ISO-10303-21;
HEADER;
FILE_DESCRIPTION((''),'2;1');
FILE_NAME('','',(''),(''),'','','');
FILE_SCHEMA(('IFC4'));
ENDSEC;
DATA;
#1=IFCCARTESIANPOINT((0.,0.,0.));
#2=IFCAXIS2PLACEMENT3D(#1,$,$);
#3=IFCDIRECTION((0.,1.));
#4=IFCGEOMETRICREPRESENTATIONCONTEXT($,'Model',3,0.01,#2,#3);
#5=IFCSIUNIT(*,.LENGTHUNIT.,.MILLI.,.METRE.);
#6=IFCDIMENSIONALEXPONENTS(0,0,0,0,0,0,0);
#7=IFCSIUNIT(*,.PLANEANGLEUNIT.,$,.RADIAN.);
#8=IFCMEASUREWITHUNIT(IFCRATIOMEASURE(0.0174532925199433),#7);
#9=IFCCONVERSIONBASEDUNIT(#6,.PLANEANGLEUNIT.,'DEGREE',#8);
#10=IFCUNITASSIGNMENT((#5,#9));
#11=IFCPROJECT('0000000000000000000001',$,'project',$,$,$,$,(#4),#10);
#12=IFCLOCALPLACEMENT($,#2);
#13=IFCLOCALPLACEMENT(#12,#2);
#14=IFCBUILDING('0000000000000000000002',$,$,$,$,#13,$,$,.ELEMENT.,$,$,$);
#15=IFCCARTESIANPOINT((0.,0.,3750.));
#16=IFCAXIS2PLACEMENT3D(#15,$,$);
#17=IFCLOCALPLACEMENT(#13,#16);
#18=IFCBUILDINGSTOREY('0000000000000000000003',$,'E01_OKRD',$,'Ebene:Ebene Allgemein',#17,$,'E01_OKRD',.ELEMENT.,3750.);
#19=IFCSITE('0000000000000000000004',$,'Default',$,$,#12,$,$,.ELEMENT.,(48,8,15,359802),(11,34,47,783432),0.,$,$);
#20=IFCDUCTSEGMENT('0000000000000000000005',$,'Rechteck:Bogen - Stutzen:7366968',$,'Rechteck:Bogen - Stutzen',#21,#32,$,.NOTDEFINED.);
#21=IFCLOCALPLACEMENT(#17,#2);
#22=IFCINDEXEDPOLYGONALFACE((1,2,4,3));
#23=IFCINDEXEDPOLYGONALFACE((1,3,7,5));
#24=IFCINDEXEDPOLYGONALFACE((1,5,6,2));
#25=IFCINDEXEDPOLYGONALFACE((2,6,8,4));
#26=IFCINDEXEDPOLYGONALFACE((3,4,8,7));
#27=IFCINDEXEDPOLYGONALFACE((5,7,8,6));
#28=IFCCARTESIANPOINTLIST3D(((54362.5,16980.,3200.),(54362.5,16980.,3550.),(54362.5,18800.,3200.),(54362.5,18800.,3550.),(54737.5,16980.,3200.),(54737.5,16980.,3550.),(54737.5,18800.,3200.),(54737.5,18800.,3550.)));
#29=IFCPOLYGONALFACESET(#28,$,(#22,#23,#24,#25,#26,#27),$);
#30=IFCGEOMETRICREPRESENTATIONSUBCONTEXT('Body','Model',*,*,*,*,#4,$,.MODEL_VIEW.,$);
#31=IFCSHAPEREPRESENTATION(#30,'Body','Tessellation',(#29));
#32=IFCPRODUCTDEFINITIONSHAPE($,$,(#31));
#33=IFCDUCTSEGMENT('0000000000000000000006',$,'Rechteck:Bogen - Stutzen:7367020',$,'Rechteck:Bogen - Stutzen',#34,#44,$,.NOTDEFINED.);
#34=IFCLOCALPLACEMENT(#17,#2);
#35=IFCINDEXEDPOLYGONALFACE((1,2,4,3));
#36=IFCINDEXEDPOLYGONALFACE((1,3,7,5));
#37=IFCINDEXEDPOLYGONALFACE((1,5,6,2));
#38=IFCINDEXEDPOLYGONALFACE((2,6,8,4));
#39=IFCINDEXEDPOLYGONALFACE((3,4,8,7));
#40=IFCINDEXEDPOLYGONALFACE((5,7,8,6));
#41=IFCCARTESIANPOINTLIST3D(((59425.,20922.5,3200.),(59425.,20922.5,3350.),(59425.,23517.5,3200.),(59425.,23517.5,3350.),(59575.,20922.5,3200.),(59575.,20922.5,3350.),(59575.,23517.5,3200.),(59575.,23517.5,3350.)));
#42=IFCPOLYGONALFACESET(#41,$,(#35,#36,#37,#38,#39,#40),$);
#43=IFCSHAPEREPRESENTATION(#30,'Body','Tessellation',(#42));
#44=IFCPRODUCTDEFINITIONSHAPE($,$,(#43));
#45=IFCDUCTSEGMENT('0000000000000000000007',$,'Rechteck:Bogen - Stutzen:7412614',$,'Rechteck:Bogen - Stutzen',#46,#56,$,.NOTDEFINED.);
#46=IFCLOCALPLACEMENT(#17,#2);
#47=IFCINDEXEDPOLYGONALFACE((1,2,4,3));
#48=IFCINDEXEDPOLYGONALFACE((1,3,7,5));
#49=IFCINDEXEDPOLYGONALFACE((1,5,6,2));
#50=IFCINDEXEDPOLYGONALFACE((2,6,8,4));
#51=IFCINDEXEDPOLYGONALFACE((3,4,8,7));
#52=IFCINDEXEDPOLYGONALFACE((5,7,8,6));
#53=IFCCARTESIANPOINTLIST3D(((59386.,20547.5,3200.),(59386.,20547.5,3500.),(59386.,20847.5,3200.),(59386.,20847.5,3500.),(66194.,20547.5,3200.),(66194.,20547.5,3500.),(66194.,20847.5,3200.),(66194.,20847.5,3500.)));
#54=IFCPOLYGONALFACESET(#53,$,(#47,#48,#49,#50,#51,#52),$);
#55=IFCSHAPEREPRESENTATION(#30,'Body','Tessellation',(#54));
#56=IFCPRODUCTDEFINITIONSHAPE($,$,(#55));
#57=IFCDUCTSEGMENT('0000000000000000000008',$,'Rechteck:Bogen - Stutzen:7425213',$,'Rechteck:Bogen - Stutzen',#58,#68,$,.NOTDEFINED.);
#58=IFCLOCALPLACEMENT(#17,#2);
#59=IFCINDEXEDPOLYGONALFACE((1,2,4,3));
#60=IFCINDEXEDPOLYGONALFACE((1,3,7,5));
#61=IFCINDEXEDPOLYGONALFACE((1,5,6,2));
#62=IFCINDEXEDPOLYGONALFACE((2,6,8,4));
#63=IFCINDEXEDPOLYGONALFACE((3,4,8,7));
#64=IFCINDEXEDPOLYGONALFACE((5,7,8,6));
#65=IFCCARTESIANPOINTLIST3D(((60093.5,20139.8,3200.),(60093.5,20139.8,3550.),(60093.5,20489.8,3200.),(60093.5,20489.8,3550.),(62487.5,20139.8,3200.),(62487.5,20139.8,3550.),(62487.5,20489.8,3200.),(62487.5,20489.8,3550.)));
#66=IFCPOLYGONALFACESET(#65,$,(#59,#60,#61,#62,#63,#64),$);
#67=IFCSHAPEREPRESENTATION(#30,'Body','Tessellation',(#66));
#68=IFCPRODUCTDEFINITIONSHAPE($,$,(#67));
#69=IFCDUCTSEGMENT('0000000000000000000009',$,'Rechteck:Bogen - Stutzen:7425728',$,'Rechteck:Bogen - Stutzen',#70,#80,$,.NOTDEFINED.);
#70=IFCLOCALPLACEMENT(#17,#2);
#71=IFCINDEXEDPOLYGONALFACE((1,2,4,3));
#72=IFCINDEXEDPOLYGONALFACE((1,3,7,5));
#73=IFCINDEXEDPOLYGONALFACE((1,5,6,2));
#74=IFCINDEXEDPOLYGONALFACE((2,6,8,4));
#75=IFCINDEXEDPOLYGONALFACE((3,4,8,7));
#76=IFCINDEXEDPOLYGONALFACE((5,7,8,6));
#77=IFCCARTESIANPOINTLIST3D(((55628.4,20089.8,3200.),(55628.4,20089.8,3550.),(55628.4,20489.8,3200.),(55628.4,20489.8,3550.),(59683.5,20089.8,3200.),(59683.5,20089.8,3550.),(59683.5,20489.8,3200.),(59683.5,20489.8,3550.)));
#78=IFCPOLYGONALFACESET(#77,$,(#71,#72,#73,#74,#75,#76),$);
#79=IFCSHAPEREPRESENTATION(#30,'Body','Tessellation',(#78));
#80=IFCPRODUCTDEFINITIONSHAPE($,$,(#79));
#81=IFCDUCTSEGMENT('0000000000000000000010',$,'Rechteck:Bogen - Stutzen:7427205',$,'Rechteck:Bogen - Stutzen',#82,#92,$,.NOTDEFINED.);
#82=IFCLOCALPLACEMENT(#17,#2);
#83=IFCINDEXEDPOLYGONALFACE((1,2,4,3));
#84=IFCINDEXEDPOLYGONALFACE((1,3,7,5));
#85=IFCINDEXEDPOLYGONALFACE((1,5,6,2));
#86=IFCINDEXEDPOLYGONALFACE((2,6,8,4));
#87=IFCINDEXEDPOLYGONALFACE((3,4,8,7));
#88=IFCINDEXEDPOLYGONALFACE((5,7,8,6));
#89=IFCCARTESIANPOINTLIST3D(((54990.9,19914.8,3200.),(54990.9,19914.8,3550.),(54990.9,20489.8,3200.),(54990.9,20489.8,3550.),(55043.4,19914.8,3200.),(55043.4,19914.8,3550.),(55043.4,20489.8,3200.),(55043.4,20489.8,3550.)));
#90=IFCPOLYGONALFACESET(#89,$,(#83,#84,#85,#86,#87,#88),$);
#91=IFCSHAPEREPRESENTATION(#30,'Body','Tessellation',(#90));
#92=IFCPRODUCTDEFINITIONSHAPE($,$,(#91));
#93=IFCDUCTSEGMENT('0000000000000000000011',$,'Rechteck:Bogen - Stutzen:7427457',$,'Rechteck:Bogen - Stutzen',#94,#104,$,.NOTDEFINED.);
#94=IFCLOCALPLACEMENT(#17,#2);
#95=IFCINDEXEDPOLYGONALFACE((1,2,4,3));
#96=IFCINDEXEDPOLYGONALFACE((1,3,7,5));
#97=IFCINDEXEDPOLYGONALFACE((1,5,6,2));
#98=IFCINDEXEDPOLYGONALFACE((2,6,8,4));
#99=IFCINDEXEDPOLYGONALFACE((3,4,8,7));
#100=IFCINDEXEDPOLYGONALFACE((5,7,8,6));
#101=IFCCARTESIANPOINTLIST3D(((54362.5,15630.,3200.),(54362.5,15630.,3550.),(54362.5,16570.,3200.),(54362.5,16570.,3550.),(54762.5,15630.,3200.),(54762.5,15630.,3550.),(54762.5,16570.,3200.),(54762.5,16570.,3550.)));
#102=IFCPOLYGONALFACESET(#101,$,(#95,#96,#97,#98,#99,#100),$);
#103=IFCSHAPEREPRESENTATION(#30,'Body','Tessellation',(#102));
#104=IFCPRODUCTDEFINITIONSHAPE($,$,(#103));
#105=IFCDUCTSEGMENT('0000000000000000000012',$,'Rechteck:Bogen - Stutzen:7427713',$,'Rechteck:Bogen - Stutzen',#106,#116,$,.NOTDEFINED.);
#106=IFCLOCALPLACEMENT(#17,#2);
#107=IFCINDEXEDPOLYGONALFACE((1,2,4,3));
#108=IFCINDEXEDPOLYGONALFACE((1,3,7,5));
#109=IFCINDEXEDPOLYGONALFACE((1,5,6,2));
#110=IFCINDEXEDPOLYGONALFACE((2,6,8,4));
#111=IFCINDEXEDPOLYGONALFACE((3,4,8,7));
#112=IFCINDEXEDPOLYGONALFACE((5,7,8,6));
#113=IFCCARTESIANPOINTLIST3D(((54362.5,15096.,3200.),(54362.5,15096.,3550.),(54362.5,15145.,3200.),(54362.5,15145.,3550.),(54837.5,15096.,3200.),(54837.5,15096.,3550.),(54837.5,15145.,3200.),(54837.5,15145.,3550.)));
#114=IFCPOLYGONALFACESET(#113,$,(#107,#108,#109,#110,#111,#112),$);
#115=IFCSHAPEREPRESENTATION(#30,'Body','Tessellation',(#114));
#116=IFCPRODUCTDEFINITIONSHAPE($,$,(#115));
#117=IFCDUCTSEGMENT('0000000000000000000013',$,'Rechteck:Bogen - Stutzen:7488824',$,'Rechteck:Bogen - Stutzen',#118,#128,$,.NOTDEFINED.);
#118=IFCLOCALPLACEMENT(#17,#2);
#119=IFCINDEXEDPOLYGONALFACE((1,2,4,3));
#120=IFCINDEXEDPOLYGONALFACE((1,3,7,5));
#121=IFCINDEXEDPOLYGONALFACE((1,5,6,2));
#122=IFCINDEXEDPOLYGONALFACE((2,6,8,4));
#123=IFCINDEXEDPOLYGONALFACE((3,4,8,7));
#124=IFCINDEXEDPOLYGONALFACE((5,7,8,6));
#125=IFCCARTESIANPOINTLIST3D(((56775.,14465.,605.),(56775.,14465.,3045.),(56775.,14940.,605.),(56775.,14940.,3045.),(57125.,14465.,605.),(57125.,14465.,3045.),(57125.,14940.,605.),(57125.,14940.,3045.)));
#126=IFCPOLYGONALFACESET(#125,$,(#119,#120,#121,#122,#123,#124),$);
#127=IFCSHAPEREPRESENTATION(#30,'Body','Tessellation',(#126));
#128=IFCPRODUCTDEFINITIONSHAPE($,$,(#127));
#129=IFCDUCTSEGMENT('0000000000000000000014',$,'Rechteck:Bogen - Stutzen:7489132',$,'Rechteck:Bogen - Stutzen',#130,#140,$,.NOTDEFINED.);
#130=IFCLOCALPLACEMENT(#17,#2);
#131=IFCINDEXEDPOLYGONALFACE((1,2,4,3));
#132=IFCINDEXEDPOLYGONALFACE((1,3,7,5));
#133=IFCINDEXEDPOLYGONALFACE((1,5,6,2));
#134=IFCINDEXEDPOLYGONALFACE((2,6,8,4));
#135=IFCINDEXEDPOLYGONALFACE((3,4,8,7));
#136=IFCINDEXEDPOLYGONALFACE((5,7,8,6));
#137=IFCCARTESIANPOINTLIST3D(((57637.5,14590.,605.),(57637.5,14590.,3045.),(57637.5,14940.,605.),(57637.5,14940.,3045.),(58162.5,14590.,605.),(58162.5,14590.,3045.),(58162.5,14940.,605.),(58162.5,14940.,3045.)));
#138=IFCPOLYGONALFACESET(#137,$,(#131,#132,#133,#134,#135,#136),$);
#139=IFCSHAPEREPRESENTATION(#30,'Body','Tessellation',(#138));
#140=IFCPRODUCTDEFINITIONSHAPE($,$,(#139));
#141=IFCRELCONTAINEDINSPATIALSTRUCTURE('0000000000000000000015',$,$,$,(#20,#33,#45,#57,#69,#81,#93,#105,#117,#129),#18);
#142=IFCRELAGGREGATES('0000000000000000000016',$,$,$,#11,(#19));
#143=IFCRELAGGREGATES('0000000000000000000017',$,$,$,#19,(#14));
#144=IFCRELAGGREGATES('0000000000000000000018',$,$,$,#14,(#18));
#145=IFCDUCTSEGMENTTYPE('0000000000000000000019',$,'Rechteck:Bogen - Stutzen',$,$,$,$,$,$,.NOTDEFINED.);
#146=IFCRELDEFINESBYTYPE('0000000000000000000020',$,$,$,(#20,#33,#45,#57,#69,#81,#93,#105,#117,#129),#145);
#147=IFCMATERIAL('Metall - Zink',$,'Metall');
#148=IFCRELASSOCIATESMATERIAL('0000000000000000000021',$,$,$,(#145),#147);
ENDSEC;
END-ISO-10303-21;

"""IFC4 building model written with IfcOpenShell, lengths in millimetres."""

from ifc_helpers import new_model, entity, si_unit, converted_unit, direction, frame, frame_2d, origin, origin_2d_with_axis, place, context, subcontext, project, spatial, rectangle, extrude, material, type_object, element, save


model = new_model("IFC4")

# Units and contexts
model_context = context("Model", 3, precision=0.01, world=origin(), true_north=direction((0.0, 1.0)))
body_context = subcontext(model_context, "Body", "Model", "MODEL_VIEW")
ifc_project = project(units=[si_unit("LENGTHUNIT", "METRE", prefix="MILLI"), converted_unit("PLANEANGLEUNIT", "DEGREE", entity("IfcRatioMeasure", 0.0174532925199433), si_unit("PLANEANGLEUNIT", "RADIAN"), dimensions=[0, 0, 0, 0, 0, 0, 0])], contexts=[model_context])

# Site, building, storey
site_placement = place(None, origin())
site = spatial("IfcSite", under=ifc_project, at=site_placement, Name="Default", CompositionType="ELEMENT", RefLatitude=(48, 8, 15, 359802), RefLongitude=(11, 34, 47, 783432), RefElevation=0.0)
building_placement = place(site_placement, origin())
building = spatial("IfcBuilding", under=site, at=building_placement, CompositionType="ELEMENT")
storey_placement = place(building_placement, frame((0.0, 0.0, 3750.0)))
storey = spatial("IfcBuildingStorey", under=building, at=storey_placement, Name="E01_OKRD", ObjectType="Ebene:Ebene Allgemein", LongName="E01_OKRD", CompositionType="ELEMENT", Elevation=3750.0)

# Duct segments
ifc_material_1 = material(Name="Metall - Zink", Category="Metall")
duct_segment_type_1 = type_object("IfcDuctSegmentType", Name="Rechteck:Bogen - Stutzen", PredefinedType="NOTDEFINED", material=ifc_material_1)
duct_segment_1_placement = place(storey_placement, frame((54362.5, 16980.0, 3200.0)))
element("IfcDuctSegment", 1, at=duct_segment_1_placement, inside=storey, type_object=duct_segment_type_1, Name="Rechteck:Bogen - Stutzen:7366968", ObjectType="Rechteck:Bogen - Stutzen", PredefinedType="NOTDEFINED", context=body_context, shape_type="SweptSolid", body=[
    extrude(rectangle(XDim=1820.0, YDim=375.0, at=frame_2d((0.0, 0.0), x_axis=(1.0, 0.0))), frame((187.5, 910.0, 0.0), z_axis=(0.0, 0.0, 1.0), x_axis=(0.0, -1.0, 0.0)), (0.0, 0.0, 1.0), 350.0),
])
duct_segment_2_placement = place(storey_placement, frame((59425.0, 20922.5, 3200.0)))
element("IfcDuctSegment", 2, at=duct_segment_2_placement, inside=storey, type_object=duct_segment_type_1, Name="Rechteck:Bogen - Stutzen:7367020", ObjectType="Rechteck:Bogen - Stutzen", PredefinedType="NOTDEFINED", context=body_context, shape_type="SweptSolid", body=[
    extrude(rectangle(XDim=2595.0, YDim=150.0, at=frame_2d((0.0, 0.0), x_axis=(1.0, 0.0))), frame((75.0, 1297.5, 0.0), z_axis=(0.0, 0.0, 1.0), x_axis=(0.0, 1.0, 0.0)), (0.0, 0.0, 1.0), 150.0),
])
duct_segment_3_placement = place(storey_placement, frame((59386.0, 20547.5, 3200.0)))
element("IfcDuctSegment", 3, at=duct_segment_3_placement, inside=storey, type_object=duct_segment_type_1, Name="Rechteck:Bogen - Stutzen:7412614", ObjectType="Rechteck:Bogen - Stutzen", PredefinedType="NOTDEFINED", context=body_context, shape_type="SweptSolid", body=[
    extrude(rectangle(XDim=6808.0, YDim=300.0, at=frame_2d((0.0, 0.0), x_axis=(1.0, 0.0))), frame((3404.0, 150.0, 0.0)), (0.0, 0.0, 1.0), 300.0),
])
duct_segment_4_placement = place(storey_placement, frame((60093.5, 20139.8, 3200.0)))
element("IfcDuctSegment", 4, at=duct_segment_4_placement, inside=storey, type_object=duct_segment_type_1, Name="Rechteck:Bogen - Stutzen:7425213", ObjectType="Rechteck:Bogen - Stutzen", PredefinedType="NOTDEFINED", context=body_context, shape_type="SweptSolid", body=[
    extrude(rectangle(XDim=2393.9, YDim=350.0, at=origin_2d_with_axis()), frame((1197.0, 175.0, 0.0)), (0.0, 0.0, 1.0), 350.0),
])
duct_segment_5_placement = place(storey_placement, frame((55628.4, 20089.8, 3200.0)))
element("IfcDuctSegment", 5, at=duct_segment_5_placement, inside=storey, type_object=duct_segment_type_1, Name="Rechteck:Bogen - Stutzen:7425728", ObjectType="Rechteck:Bogen - Stutzen", PredefinedType="NOTDEFINED", context=body_context, shape_type="SweptSolid", body=[
    extrude(rectangle(XDim=4055.2, YDim=400.0, at=frame_2d((0.0, 0.0), x_axis=(1.0, 0.0))), frame((2027.6, 200.0, 0.0)), (0.0, 0.0, 1.0), 350.0),
])
duct_segment_6_placement = place(storey_placement, frame((54990.9, 19914.8, 3200.0)))
element("IfcDuctSegment", 6, at=duct_segment_6_placement, inside=storey, type_object=duct_segment_type_1, Name="Rechteck:Bogen - Stutzen:7427205", ObjectType="Rechteck:Bogen - Stutzen", PredefinedType="NOTDEFINED", context=body_context, shape_type="SweptSolid", body=[
    extrude(rectangle(XDim=52.5, YDim=575.0, at=frame_2d((0.0, 0.0), x_axis=(1.0, 0.0))), frame((26.2, 287.5, 0.0), z_axis=(0.0, 0.0, 1.0), x_axis=(-1.0, 0.0, 0.0)), (0.0, 0.0, 1.0), 350.0),
])
duct_segment_7_placement = place(storey_placement, frame((54362.5, 15630.0, 3200.0)))
element("IfcDuctSegment", 7, at=duct_segment_7_placement, inside=storey, type_object=duct_segment_type_1, Name="Rechteck:Bogen - Stutzen:7427457", ObjectType="Rechteck:Bogen - Stutzen", PredefinedType="NOTDEFINED", context=body_context, shape_type="SweptSolid", body=[
    extrude(rectangle(XDim=940.0, YDim=400.0, at=frame_2d((0.0, 0.0), x_axis=(1.0, 0.0))), frame((200.0, 470.0, 0.0), z_axis=(0.0, 0.0, 1.0), x_axis=(0.0, -1.0, 0.0)), (0.0, 0.0, 1.0), 350.0),
])
duct_segment_8_placement = place(storey_placement, frame((54362.5, 15096.0, 3200.0)))
element("IfcDuctSegment", 8, at=duct_segment_8_placement, inside=storey, type_object=duct_segment_type_1, Name="Rechteck:Bogen - Stutzen:7427713", ObjectType="Rechteck:Bogen - Stutzen", PredefinedType="NOTDEFINED", context=body_context, shape_type="SweptSolid", body=[
    extrude(rectangle(XDim=49.0, YDim=475.0, at=frame_2d((0.0, 0.0), x_axis=(1.0, 0.0))), frame((237.5, 24.5, 0.0), z_axis=(0.0, 0.0, 1.0), x_axis=(0.0, 1.0, 0.0)), (0.0, 0.0, 1.0), 350.0),
])
duct_segment_9_placement = place(storey_placement, frame((56775.0, 14465.0, 605.0)))
element("IfcDuctSegment", 9, at=duct_segment_9_placement, inside=storey, type_object=duct_segment_type_1, Name="Rechteck:Bogen - Stutzen:7488824", ObjectType="Rechteck:Bogen - Stutzen", PredefinedType="NOTDEFINED", context=body_context, shape_type="SweptSolid", body=[
    extrude(rectangle(XDim=475.0, YDim=350.0, at=frame_2d((0.0, 0.0), x_axis=(1.0, 0.0))), frame((175.0, 237.5, 0.0), z_axis=(0.0, 0.0, 1.0), x_axis=(0.0, -1.0, 0.0)), (0.0, 0.0, 1.0), 2440.0),
])
duct_segment_10_placement = place(storey_placement, frame((57637.5, 14590.0, 605.0)))
element("IfcDuctSegment", 10, at=duct_segment_10_placement, inside=storey, type_object=duct_segment_type_1, Name="Rechteck:Bogen - Stutzen:7489132", ObjectType="Rechteck:Bogen - Stutzen", PredefinedType="NOTDEFINED", context=body_context, shape_type="SweptSolid", body=[
    extrude(rectangle(XDim=525.0, YDim=350.0, at=frame_2d((0.0, 0.0), x_axis=(1.0, 0.0))), frame((262.5, 175.0, 0.0)), (0.0, 0.0, 1.0), 2440.0),
])

save(model, "model.ifc")
